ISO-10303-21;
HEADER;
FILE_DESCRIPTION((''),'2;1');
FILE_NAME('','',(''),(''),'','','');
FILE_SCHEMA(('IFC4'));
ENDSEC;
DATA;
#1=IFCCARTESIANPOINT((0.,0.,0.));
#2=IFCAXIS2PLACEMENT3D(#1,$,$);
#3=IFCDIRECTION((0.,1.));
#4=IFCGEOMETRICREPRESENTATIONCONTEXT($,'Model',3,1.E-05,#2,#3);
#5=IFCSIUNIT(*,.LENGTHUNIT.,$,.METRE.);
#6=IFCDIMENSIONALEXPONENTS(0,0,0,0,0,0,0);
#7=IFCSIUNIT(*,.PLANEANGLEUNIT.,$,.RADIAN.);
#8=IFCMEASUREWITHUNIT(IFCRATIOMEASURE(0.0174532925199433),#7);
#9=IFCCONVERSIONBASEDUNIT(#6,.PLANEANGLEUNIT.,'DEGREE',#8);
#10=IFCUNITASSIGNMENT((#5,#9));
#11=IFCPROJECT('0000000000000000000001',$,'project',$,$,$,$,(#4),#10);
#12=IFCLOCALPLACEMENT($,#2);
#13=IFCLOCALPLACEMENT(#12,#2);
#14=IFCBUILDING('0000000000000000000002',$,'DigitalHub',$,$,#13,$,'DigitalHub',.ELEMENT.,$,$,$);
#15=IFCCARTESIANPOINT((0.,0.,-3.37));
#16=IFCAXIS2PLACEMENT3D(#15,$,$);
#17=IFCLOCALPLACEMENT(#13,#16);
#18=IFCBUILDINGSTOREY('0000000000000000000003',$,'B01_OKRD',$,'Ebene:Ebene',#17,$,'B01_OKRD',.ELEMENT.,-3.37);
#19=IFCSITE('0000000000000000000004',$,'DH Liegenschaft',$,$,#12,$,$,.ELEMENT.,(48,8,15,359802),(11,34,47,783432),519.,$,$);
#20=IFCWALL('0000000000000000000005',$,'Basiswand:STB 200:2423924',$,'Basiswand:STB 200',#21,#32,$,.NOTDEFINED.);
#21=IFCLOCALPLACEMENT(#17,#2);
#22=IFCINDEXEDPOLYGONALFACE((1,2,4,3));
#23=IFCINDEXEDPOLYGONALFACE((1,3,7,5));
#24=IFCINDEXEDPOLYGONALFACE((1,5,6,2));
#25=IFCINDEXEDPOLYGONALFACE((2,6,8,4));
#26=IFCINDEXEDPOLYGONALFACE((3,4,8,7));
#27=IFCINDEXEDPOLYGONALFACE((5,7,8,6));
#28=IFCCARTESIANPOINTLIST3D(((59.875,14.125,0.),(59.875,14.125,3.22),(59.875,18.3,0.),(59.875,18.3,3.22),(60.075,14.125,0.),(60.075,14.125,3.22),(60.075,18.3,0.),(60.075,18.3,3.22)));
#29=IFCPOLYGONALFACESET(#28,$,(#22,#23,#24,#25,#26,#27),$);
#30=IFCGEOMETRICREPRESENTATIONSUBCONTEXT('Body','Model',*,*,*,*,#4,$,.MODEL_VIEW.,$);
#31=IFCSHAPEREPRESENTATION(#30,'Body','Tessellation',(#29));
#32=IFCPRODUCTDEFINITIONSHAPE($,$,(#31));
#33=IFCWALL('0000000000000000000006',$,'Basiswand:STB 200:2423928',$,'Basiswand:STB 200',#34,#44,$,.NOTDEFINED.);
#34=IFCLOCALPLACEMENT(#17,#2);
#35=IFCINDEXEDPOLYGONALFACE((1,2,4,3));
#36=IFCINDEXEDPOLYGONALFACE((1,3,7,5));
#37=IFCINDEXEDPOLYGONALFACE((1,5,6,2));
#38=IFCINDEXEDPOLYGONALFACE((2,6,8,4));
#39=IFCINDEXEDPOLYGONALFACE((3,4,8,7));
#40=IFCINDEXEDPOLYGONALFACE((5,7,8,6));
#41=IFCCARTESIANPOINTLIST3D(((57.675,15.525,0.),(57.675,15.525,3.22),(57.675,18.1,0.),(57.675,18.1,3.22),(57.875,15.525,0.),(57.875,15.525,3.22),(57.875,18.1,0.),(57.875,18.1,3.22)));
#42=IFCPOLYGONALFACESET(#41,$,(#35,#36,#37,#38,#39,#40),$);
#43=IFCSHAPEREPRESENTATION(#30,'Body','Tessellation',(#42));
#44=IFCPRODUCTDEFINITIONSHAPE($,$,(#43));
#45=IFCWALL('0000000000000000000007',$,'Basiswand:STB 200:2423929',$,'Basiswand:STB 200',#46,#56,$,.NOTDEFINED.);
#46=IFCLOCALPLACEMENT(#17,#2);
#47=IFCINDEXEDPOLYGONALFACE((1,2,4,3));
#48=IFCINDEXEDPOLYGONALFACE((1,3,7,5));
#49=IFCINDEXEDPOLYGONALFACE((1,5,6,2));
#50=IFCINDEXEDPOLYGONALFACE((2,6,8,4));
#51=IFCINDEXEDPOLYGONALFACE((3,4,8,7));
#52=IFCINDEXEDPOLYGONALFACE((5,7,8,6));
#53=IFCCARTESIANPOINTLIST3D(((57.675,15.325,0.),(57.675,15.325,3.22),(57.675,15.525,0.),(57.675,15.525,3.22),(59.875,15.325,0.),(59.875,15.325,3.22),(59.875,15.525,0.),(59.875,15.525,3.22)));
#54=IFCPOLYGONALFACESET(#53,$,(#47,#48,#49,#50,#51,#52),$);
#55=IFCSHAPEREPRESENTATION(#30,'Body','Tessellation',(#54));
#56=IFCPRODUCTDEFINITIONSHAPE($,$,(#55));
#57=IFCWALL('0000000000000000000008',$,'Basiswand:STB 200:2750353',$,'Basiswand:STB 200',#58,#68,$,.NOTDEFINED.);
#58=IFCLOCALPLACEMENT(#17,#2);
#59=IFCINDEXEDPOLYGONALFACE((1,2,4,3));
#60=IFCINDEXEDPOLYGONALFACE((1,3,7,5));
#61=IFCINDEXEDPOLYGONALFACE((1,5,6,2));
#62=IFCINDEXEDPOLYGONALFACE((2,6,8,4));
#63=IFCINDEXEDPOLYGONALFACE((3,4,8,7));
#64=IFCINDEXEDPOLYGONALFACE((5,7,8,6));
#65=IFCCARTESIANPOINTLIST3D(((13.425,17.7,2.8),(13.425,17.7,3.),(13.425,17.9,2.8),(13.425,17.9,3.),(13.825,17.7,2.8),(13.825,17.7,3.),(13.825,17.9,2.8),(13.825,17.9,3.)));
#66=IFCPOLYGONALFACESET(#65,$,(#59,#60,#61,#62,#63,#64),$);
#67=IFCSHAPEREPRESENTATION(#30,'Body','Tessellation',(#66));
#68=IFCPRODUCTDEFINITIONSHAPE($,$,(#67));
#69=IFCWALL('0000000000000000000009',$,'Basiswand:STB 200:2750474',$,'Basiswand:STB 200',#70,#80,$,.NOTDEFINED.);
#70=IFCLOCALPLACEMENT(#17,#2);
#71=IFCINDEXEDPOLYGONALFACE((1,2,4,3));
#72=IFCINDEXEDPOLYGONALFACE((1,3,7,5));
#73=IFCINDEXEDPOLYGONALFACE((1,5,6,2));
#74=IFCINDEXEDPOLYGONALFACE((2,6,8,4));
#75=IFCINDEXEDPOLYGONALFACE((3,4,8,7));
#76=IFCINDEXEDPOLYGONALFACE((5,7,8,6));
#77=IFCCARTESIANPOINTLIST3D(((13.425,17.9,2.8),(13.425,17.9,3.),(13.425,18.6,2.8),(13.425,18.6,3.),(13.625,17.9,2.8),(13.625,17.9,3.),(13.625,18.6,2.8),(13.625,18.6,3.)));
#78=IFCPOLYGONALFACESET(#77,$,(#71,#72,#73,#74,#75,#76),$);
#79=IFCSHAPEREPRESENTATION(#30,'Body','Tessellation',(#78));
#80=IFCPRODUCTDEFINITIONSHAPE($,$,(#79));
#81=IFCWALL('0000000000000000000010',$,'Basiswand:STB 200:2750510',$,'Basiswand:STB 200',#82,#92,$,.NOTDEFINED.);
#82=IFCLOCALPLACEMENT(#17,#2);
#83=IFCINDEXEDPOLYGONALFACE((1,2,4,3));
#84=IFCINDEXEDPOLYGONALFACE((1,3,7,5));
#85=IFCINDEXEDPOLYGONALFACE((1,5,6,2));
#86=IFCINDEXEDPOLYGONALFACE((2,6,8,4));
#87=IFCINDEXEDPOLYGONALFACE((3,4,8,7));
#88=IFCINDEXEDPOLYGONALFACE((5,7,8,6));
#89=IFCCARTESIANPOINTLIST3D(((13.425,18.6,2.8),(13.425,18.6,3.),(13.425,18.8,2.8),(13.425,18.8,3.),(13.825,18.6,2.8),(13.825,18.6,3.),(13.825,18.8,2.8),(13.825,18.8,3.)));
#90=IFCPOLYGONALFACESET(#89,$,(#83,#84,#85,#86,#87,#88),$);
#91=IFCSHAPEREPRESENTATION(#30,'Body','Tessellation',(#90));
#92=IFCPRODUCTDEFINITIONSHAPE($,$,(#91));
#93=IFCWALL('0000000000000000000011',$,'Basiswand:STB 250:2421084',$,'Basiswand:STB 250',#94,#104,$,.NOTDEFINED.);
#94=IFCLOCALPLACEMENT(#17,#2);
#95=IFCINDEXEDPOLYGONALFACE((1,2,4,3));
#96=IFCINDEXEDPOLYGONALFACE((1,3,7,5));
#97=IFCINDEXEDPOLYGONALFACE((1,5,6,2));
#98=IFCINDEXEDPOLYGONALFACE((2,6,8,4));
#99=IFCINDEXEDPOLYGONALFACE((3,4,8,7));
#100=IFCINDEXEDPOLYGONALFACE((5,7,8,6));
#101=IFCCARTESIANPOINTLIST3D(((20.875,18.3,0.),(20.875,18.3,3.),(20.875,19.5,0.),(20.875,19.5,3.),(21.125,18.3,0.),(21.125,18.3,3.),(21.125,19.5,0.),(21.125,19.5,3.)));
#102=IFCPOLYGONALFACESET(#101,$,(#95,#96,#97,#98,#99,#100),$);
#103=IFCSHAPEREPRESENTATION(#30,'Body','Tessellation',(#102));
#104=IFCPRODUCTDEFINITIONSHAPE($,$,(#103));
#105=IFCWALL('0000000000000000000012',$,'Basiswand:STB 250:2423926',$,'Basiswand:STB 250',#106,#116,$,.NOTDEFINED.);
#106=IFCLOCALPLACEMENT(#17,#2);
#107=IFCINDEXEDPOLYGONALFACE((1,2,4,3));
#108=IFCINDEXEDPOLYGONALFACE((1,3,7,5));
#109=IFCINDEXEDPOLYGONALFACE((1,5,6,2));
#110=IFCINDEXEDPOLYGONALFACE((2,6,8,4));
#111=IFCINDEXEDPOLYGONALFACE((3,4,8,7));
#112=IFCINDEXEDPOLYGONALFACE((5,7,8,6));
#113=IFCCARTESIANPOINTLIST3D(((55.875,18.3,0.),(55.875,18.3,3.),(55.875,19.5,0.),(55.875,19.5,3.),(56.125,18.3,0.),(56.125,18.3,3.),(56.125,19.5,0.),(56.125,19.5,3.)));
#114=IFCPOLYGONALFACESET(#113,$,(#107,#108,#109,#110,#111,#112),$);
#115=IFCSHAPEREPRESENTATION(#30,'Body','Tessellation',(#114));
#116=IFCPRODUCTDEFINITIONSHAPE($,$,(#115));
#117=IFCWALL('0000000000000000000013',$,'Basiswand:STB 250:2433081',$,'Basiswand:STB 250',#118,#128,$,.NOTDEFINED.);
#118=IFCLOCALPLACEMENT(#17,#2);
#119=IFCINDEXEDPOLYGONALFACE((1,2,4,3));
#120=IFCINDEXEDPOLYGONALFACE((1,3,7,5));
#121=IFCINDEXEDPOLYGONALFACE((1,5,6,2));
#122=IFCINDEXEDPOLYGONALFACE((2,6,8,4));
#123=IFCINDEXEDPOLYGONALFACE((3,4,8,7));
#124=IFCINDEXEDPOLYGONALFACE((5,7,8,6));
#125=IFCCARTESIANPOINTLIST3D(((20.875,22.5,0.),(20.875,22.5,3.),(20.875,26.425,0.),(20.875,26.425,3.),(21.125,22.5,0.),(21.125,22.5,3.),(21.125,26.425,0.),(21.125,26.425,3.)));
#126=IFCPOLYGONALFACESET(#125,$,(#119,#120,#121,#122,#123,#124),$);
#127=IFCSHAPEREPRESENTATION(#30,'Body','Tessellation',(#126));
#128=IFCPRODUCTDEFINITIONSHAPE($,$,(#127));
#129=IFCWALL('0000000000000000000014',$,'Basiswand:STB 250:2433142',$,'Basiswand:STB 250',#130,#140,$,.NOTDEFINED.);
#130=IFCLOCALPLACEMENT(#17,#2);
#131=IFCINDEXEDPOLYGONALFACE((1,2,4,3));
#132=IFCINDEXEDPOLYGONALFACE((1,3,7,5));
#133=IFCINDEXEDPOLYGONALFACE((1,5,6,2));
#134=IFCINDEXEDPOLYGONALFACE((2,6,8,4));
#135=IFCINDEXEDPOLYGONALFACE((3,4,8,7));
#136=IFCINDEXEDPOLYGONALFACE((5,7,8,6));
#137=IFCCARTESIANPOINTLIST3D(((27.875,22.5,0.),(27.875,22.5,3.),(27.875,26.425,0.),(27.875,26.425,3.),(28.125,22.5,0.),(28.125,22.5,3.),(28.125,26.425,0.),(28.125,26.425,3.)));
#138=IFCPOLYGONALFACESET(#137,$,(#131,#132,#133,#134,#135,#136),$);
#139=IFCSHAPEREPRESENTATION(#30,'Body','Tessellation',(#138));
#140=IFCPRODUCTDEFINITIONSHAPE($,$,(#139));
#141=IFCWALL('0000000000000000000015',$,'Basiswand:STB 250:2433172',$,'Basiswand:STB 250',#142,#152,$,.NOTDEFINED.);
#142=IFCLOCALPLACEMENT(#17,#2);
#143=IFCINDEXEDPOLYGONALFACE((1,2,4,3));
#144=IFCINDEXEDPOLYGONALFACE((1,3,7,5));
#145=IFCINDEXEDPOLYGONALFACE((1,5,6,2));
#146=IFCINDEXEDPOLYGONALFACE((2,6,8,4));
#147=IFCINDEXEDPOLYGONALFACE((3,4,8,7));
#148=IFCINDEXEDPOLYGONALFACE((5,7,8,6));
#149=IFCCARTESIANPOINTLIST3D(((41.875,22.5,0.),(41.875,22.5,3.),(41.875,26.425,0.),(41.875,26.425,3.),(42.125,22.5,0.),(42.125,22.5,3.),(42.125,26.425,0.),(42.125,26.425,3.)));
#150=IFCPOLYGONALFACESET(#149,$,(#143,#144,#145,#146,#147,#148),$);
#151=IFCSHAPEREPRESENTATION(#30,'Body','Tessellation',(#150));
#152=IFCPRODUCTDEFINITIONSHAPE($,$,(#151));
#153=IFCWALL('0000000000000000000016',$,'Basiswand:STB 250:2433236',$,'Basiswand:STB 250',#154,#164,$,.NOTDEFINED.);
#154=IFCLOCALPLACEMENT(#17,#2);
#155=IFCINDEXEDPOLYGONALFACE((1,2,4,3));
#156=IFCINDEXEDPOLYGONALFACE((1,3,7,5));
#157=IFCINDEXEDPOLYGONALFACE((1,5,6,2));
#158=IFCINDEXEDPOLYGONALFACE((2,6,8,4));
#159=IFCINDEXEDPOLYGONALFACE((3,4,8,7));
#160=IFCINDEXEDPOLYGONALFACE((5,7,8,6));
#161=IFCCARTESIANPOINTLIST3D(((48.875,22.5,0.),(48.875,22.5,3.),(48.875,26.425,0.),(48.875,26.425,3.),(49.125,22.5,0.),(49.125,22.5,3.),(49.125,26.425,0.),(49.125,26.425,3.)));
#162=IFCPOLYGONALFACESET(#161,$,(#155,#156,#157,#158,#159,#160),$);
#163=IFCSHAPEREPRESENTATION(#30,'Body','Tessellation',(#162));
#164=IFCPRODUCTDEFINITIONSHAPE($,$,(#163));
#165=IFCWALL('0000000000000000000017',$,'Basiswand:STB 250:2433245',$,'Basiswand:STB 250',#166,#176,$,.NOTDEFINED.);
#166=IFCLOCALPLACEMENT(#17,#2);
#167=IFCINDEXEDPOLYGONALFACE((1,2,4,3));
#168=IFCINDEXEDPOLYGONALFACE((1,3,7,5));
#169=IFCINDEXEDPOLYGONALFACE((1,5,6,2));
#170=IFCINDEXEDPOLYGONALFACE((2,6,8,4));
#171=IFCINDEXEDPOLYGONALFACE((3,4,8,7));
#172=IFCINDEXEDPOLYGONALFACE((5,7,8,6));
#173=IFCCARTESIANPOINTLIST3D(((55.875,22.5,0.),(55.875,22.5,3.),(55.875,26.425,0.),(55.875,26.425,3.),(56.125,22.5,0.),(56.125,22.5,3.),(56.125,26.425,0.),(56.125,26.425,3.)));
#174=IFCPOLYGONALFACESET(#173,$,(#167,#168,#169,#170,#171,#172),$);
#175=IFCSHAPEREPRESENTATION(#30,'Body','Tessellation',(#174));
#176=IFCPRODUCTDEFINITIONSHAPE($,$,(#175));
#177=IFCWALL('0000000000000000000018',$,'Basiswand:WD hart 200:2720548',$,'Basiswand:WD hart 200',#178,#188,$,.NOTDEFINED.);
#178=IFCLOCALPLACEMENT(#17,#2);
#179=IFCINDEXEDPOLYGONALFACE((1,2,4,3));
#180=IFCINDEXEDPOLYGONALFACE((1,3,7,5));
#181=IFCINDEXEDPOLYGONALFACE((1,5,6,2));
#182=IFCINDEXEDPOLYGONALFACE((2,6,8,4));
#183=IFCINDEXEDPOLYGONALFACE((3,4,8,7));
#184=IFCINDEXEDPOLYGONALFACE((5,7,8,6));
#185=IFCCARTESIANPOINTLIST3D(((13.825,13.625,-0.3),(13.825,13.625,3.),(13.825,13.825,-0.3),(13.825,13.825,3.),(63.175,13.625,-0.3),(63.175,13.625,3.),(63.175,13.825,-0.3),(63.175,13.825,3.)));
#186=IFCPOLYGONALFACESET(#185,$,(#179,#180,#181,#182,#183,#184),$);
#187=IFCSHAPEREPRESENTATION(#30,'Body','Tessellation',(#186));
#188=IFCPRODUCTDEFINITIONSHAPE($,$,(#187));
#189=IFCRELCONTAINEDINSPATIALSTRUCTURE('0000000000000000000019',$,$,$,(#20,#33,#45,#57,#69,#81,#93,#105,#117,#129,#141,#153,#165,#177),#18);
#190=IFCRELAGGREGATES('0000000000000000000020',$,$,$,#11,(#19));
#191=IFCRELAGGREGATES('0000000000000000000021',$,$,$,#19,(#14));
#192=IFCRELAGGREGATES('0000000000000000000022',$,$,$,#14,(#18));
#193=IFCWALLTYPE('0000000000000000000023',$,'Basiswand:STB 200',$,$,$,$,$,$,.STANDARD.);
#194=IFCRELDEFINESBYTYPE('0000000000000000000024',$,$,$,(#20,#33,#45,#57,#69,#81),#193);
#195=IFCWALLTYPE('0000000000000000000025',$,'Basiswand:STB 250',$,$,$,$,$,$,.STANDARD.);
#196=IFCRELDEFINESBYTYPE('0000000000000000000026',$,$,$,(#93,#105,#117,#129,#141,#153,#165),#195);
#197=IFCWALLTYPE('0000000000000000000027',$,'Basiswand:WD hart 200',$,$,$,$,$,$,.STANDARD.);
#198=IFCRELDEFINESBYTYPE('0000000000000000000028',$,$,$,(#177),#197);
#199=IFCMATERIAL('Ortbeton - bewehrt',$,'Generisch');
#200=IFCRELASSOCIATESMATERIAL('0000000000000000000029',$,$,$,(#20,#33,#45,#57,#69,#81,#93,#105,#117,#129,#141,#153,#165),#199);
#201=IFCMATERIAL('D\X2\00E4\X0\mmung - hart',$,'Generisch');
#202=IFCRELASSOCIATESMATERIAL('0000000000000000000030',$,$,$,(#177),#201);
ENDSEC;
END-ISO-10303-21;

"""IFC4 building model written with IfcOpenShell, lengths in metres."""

from ifc_helpers import new_model, entity, si_unit, converted_unit, direction, frame, origin, place, context, subcontext, project, spatial, indexed_curve, outline, extrude, material, type_object, element, save


model = new_model("IFC4")

# Units and contexts
model_context = context("Model", 3, precision=1e-05, world=origin(), true_north=direction((0.0, 1.0)))
body_context = subcontext(model_context, "Body", "Model", "MODEL_VIEW")
ifc_project = project(units=[si_unit("LENGTHUNIT", "METRE"), converted_unit("PLANEANGLEUNIT", "DEGREE", entity("IfcRatioMeasure", 0.0174532925199433), si_unit("PLANEANGLEUNIT", "RADIAN"), dimensions=[0, 0, 0, 0, 0, 0, 0])], contexts=[model_context])

# Site, building, storey
site_placement = place(None, frame((0.0, 0.0, 0.0)))
site = spatial("IfcSite", under=ifc_project, at=site_placement, Name="DH Liegenschaft", CompositionType="ELEMENT", RefLatitude=(48, 8, 15, 359802), RefLongitude=(11, 34, 47, 783432), RefElevation=519.0)
building_placement = place(site_placement, origin())
building = spatial("IfcBuilding", under=site, at=building_placement, Name="DigitalHub", LongName="DigitalHub", CompositionType="ELEMENT")
storey_placement = place(building_placement, frame((0.0, 0.0, -3.37)))
storey = spatial("IfcBuildingStorey", under=building, at=storey_placement, Name="B01_OKRD", ObjectType="Ebene:Ebene", LongName="B01_OKRD", CompositionType="ELEMENT", Elevation=-3.37)

# Shared definitions
ifc_material_1 = material(Name="Ortbeton - bewehrt", Category="Generisch")
ifc_material_2 = material(Name="Dämmung - hart", Category="Generisch")

# Walls
wall_type_1 = type_object("IfcWallType", Name="Basiswand:STB 200", PredefinedType="STANDARD")
wall_1_placement = place(storey_placement, frame((59.975, 14.125, 0.0), z_axis=(0.0, 0.0, 1.0), x_axis=(0.0, 1.0, 0.0)))
element("IfcWall", 1, at=wall_1_placement, inside=storey, type_object=wall_type_1, material=ifc_material_1, Name="Basiswand:STB 200:2423924", ObjectType="Basiswand:STB 200", PredefinedType="NOTDEFINED", context=body_context, shape_type="SweptSolid", body=[
    extrude(outline(indexed_curve([(4.175, 0.1), (0.0, 0.1), (0.0, -0.1), (4.175, -0.1), (4.175, 0.1)], self_intersect=False)), origin(), (0.0, 0.0, 1.0), 3.22),
])
wall_2_placement = place(storey_placement, frame((57.775, 15.525, 0.0), z_axis=(0.0, 0.0, 1.0), x_axis=(0.0, 1.0, 0.0)))
element("IfcWall", 2, at=wall_2_placement, inside=storey, type_object=wall_type_1, material=ifc_material_1, Name="Basiswand:STB 200:2423928", ObjectType="Basiswand:STB 200", PredefinedType="NOTDEFINED", context=body_context, shape_type="SweptSolid", body=[
    extrude(outline(indexed_curve([(2.575, 0.1), (0.0, 0.1), (0.0, -0.1), (2.575, -0.1), (2.575, 0.1)], self_intersect=False)), origin(), (0.0, 0.0, 1.0), 3.22),
])
wall_3_placement = place(storey_placement, frame((59.875, 15.425, 0.0), z_axis=(0.0, 0.0, 1.0), x_axis=(-1.0, 0.0, 0.0)))
element("IfcWall", 3, at=wall_3_placement, inside=storey, type_object=wall_type_1, material=ifc_material_1, Name="Basiswand:STB 200:2423929", ObjectType="Basiswand:STB 200", PredefinedType="NOTDEFINED", context=body_context, shape_type="SweptSolid", body=[
    extrude(outline(indexed_curve([(2.2, 0.1), (0.0, 0.1), (0.0, -0.1), (2.2, -0.1), (2.2, 0.1)], self_intersect=False)), origin(), (0.0, 0.0, 1.0), 3.22),
])
wall_4_placement = place(storey_placement, frame((13.825, 17.8, 2.8), z_axis=(0.0, 0.0, 1.0), x_axis=(-1.0, 0.0, 0.0)))
element("IfcWall", 4, at=wall_4_placement, inside=storey, type_object=wall_type_1, material=ifc_material_1, Name="Basiswand:STB 200:2750353", ObjectType="Basiswand:STB 200", PredefinedType="NOTDEFINED", context=body_context, shape_type="SweptSolid", body=[
    extrude(outline(indexed_curve([(0.4, 0.1), (0.0, 0.1), (0.0, -0.1), (0.4, -0.1), (0.4, 0.1)], self_intersect=False)), origin(), (0.0, 0.0, 1.0), 0.2),
])
wall_5_placement = place(storey_placement, frame((13.525, 17.9, 2.8), z_axis=(0.0, 0.0, 1.0), x_axis=(0.0, 1.0, 0.0)))
element("IfcWall", 5, at=wall_5_placement, inside=storey, type_object=wall_type_1, material=ifc_material_1, Name="Basiswand:STB 200:2750474", ObjectType="Basiswand:STB 200", PredefinedType="NOTDEFINED", context=body_context, shape_type="SweptSolid", body=[
    extrude(outline(indexed_curve([(0.7, 0.1), (0.0, 0.1), (0.0, -0.1), (0.7, -0.1), (0.7, 0.1)], self_intersect=False)), origin(), (0.0, 0.0, 1.0), 0.2),
])
wall_6_placement = place(storey_placement, frame((13.425, 18.7, 2.8)))
element("IfcWall", 6, at=wall_6_placement, inside=storey, type_object=wall_type_1, material=ifc_material_1, Name="Basiswand:STB 200:2750510", ObjectType="Basiswand:STB 200", PredefinedType="NOTDEFINED", context=body_context, shape_type="SweptSolid", body=[
    extrude(outline(indexed_curve([(0.4, 0.1), (0.0, 0.1), (0.0, -0.1), (0.4, -0.1), (0.4, 0.1)], self_intersect=False)), origin(), (0.0, 0.0, 1.0), 0.2),
])
wall_type_2 = type_object("IfcWallType", Name="Basiswand:STB 250", PredefinedType="STANDARD")
wall_7_placement = place(storey_placement, frame((21.0, 19.5, 0.0), z_axis=(0.0, 0.0, 1.0), x_axis=(0.0, -1.0, 0.0)))
element("IfcWall", 7, at=wall_7_placement, inside=storey, type_object=wall_type_2, material=ifc_material_1, Name="Basiswand:STB 250:2421084", ObjectType="Basiswand:STB 250", PredefinedType="NOTDEFINED", context=body_context, shape_type="SweptSolid", body=[
    extrude(outline(indexed_curve([(1.2, 0.125), (0.0, 0.125), (0.0, -0.125), (1.2, -0.125), (1.2, 0.125)], self_intersect=False)), origin(), (0.0, 0.0, 1.0), 3.0),
])
wall_8_placement = place(storey_placement, frame((56.0, 19.5, 0.0), z_axis=(0.0, 0.0, 1.0), x_axis=(0.0, -1.0, 0.0)))
element("IfcWall", 8, at=wall_8_placement, inside=storey, type_object=wall_type_2, material=ifc_material_1, Name="Basiswand:STB 250:2423926", ObjectType="Basiswand:STB 250", PredefinedType="NOTDEFINED", context=body_context, shape_type="SweptSolid", body=[
    extrude(outline(indexed_curve([(1.2, 0.125), (0.0, 0.125), (0.0, -0.125), (1.2, -0.125), (1.2, 0.125)], self_intersect=False)), origin(), (0.0, 0.0, 1.0), 3.0),
])
wall_9_placement = place(storey_placement, frame((21.0, 26.425, 0.0), z_axis=(0.0, 0.0, 1.0), x_axis=(0.0, -1.0, 0.0)))
element("IfcWall", 9, at=wall_9_placement, inside=storey, type_object=wall_type_2, material=ifc_material_1, Name="Basiswand:STB 250:2433081", ObjectType="Basiswand:STB 250", PredefinedType="NOTDEFINED", context=body_context, shape_type="SweptSolid", body=[
    extrude(outline(indexed_curve([(3.925, 0.125), (0.0, 0.125), (0.0, -0.125), (3.925, -0.125), (3.925, 0.125)], self_intersect=False)), origin(), (0.0, 0.0, 1.0), 3.0),
])
wall_10_placement = place(storey_placement, frame((28.0, 26.425, 0.0), z_axis=(0.0, 0.0, 1.0), x_axis=(0.0, -1.0, 0.0)))
element("IfcWall", 10, at=wall_10_placement, inside=storey, type_object=wall_type_2, material=ifc_material_1, Name="Basiswand:STB 250:2433142", ObjectType="Basiswand:STB 250", PredefinedType="NOTDEFINED", context=body_context, shape_type="SweptSolid", body=[
    extrude(outline(indexed_curve([(3.925, 0.125), (0.0, 0.125), (0.0, -0.125), (3.925, -0.125), (3.925, 0.125)], self_intersect=False)), origin(), (0.0, 0.0, 1.0), 3.0),
])
for number, where, z_axis, x_axis, name in (
    (11, (42.0, 26.425, 0.0), (0.0, 0.0, 1.0), (0.0, -1.0, 0.0), "Basiswand:STB 250:2433172"),
    (12, (49.0, 26.425, 0.0), (0.0, 0.0, 1.0), (0.0, -1.0, 0.0), "Basiswand:STB 250:2433236"),
    (13, (56.0, 26.425, 0.0), (0.0, 0.0, 1.0), (0.0, -1.0, 0.0), "Basiswand:STB 250:2433245"),
):
    element("IfcWall", number, at=place(storey_placement, frame(where, z_axis=z_axis, x_axis=x_axis)), inside=storey, type_object=wall_type_2, material=ifc_material_1, Name=name, ObjectType="Basiswand:STB 250", PredefinedType="NOTDEFINED", context=body_context, shape_type="SweptSolid", body=[
        extrude(outline(indexed_curve([(3.925, 0.125), (0.0, 0.125), (0.0, -0.125), (3.925, -0.125), (3.925, 0.125)], self_intersect=False)), origin(), (0.0, 0.0, 1.0), 3.0),
    ])
wall_type_3 = type_object("IfcWallType", Name="Basiswand:WD hart 200", PredefinedType="STANDARD")
wall_11_placement = place(storey_placement, frame((63.175, 13.725, -0.3), z_axis=(0.0, 0.0, 1.0), x_axis=(-1.0, 0.0, 0.0)))
element("IfcWall", 14, at=wall_11_placement, inside=storey, type_object=wall_type_3, material=ifc_material_2, Name="Basiswand:WD hart 200:2720548", ObjectType="Basiswand:WD hart 200", PredefinedType="NOTDEFINED", context=body_context, shape_type="SweptSolid", body=[
    extrude(outline(indexed_curve([(49.35, 0.1), (0.0, 0.1), (0.0, -0.1), (49.35, -0.1), (49.35, 0.1)], self_intersect=False)), origin(), (0.0, 0.0, 1.0), 3.3),
])

save(model, "model.ifc")
